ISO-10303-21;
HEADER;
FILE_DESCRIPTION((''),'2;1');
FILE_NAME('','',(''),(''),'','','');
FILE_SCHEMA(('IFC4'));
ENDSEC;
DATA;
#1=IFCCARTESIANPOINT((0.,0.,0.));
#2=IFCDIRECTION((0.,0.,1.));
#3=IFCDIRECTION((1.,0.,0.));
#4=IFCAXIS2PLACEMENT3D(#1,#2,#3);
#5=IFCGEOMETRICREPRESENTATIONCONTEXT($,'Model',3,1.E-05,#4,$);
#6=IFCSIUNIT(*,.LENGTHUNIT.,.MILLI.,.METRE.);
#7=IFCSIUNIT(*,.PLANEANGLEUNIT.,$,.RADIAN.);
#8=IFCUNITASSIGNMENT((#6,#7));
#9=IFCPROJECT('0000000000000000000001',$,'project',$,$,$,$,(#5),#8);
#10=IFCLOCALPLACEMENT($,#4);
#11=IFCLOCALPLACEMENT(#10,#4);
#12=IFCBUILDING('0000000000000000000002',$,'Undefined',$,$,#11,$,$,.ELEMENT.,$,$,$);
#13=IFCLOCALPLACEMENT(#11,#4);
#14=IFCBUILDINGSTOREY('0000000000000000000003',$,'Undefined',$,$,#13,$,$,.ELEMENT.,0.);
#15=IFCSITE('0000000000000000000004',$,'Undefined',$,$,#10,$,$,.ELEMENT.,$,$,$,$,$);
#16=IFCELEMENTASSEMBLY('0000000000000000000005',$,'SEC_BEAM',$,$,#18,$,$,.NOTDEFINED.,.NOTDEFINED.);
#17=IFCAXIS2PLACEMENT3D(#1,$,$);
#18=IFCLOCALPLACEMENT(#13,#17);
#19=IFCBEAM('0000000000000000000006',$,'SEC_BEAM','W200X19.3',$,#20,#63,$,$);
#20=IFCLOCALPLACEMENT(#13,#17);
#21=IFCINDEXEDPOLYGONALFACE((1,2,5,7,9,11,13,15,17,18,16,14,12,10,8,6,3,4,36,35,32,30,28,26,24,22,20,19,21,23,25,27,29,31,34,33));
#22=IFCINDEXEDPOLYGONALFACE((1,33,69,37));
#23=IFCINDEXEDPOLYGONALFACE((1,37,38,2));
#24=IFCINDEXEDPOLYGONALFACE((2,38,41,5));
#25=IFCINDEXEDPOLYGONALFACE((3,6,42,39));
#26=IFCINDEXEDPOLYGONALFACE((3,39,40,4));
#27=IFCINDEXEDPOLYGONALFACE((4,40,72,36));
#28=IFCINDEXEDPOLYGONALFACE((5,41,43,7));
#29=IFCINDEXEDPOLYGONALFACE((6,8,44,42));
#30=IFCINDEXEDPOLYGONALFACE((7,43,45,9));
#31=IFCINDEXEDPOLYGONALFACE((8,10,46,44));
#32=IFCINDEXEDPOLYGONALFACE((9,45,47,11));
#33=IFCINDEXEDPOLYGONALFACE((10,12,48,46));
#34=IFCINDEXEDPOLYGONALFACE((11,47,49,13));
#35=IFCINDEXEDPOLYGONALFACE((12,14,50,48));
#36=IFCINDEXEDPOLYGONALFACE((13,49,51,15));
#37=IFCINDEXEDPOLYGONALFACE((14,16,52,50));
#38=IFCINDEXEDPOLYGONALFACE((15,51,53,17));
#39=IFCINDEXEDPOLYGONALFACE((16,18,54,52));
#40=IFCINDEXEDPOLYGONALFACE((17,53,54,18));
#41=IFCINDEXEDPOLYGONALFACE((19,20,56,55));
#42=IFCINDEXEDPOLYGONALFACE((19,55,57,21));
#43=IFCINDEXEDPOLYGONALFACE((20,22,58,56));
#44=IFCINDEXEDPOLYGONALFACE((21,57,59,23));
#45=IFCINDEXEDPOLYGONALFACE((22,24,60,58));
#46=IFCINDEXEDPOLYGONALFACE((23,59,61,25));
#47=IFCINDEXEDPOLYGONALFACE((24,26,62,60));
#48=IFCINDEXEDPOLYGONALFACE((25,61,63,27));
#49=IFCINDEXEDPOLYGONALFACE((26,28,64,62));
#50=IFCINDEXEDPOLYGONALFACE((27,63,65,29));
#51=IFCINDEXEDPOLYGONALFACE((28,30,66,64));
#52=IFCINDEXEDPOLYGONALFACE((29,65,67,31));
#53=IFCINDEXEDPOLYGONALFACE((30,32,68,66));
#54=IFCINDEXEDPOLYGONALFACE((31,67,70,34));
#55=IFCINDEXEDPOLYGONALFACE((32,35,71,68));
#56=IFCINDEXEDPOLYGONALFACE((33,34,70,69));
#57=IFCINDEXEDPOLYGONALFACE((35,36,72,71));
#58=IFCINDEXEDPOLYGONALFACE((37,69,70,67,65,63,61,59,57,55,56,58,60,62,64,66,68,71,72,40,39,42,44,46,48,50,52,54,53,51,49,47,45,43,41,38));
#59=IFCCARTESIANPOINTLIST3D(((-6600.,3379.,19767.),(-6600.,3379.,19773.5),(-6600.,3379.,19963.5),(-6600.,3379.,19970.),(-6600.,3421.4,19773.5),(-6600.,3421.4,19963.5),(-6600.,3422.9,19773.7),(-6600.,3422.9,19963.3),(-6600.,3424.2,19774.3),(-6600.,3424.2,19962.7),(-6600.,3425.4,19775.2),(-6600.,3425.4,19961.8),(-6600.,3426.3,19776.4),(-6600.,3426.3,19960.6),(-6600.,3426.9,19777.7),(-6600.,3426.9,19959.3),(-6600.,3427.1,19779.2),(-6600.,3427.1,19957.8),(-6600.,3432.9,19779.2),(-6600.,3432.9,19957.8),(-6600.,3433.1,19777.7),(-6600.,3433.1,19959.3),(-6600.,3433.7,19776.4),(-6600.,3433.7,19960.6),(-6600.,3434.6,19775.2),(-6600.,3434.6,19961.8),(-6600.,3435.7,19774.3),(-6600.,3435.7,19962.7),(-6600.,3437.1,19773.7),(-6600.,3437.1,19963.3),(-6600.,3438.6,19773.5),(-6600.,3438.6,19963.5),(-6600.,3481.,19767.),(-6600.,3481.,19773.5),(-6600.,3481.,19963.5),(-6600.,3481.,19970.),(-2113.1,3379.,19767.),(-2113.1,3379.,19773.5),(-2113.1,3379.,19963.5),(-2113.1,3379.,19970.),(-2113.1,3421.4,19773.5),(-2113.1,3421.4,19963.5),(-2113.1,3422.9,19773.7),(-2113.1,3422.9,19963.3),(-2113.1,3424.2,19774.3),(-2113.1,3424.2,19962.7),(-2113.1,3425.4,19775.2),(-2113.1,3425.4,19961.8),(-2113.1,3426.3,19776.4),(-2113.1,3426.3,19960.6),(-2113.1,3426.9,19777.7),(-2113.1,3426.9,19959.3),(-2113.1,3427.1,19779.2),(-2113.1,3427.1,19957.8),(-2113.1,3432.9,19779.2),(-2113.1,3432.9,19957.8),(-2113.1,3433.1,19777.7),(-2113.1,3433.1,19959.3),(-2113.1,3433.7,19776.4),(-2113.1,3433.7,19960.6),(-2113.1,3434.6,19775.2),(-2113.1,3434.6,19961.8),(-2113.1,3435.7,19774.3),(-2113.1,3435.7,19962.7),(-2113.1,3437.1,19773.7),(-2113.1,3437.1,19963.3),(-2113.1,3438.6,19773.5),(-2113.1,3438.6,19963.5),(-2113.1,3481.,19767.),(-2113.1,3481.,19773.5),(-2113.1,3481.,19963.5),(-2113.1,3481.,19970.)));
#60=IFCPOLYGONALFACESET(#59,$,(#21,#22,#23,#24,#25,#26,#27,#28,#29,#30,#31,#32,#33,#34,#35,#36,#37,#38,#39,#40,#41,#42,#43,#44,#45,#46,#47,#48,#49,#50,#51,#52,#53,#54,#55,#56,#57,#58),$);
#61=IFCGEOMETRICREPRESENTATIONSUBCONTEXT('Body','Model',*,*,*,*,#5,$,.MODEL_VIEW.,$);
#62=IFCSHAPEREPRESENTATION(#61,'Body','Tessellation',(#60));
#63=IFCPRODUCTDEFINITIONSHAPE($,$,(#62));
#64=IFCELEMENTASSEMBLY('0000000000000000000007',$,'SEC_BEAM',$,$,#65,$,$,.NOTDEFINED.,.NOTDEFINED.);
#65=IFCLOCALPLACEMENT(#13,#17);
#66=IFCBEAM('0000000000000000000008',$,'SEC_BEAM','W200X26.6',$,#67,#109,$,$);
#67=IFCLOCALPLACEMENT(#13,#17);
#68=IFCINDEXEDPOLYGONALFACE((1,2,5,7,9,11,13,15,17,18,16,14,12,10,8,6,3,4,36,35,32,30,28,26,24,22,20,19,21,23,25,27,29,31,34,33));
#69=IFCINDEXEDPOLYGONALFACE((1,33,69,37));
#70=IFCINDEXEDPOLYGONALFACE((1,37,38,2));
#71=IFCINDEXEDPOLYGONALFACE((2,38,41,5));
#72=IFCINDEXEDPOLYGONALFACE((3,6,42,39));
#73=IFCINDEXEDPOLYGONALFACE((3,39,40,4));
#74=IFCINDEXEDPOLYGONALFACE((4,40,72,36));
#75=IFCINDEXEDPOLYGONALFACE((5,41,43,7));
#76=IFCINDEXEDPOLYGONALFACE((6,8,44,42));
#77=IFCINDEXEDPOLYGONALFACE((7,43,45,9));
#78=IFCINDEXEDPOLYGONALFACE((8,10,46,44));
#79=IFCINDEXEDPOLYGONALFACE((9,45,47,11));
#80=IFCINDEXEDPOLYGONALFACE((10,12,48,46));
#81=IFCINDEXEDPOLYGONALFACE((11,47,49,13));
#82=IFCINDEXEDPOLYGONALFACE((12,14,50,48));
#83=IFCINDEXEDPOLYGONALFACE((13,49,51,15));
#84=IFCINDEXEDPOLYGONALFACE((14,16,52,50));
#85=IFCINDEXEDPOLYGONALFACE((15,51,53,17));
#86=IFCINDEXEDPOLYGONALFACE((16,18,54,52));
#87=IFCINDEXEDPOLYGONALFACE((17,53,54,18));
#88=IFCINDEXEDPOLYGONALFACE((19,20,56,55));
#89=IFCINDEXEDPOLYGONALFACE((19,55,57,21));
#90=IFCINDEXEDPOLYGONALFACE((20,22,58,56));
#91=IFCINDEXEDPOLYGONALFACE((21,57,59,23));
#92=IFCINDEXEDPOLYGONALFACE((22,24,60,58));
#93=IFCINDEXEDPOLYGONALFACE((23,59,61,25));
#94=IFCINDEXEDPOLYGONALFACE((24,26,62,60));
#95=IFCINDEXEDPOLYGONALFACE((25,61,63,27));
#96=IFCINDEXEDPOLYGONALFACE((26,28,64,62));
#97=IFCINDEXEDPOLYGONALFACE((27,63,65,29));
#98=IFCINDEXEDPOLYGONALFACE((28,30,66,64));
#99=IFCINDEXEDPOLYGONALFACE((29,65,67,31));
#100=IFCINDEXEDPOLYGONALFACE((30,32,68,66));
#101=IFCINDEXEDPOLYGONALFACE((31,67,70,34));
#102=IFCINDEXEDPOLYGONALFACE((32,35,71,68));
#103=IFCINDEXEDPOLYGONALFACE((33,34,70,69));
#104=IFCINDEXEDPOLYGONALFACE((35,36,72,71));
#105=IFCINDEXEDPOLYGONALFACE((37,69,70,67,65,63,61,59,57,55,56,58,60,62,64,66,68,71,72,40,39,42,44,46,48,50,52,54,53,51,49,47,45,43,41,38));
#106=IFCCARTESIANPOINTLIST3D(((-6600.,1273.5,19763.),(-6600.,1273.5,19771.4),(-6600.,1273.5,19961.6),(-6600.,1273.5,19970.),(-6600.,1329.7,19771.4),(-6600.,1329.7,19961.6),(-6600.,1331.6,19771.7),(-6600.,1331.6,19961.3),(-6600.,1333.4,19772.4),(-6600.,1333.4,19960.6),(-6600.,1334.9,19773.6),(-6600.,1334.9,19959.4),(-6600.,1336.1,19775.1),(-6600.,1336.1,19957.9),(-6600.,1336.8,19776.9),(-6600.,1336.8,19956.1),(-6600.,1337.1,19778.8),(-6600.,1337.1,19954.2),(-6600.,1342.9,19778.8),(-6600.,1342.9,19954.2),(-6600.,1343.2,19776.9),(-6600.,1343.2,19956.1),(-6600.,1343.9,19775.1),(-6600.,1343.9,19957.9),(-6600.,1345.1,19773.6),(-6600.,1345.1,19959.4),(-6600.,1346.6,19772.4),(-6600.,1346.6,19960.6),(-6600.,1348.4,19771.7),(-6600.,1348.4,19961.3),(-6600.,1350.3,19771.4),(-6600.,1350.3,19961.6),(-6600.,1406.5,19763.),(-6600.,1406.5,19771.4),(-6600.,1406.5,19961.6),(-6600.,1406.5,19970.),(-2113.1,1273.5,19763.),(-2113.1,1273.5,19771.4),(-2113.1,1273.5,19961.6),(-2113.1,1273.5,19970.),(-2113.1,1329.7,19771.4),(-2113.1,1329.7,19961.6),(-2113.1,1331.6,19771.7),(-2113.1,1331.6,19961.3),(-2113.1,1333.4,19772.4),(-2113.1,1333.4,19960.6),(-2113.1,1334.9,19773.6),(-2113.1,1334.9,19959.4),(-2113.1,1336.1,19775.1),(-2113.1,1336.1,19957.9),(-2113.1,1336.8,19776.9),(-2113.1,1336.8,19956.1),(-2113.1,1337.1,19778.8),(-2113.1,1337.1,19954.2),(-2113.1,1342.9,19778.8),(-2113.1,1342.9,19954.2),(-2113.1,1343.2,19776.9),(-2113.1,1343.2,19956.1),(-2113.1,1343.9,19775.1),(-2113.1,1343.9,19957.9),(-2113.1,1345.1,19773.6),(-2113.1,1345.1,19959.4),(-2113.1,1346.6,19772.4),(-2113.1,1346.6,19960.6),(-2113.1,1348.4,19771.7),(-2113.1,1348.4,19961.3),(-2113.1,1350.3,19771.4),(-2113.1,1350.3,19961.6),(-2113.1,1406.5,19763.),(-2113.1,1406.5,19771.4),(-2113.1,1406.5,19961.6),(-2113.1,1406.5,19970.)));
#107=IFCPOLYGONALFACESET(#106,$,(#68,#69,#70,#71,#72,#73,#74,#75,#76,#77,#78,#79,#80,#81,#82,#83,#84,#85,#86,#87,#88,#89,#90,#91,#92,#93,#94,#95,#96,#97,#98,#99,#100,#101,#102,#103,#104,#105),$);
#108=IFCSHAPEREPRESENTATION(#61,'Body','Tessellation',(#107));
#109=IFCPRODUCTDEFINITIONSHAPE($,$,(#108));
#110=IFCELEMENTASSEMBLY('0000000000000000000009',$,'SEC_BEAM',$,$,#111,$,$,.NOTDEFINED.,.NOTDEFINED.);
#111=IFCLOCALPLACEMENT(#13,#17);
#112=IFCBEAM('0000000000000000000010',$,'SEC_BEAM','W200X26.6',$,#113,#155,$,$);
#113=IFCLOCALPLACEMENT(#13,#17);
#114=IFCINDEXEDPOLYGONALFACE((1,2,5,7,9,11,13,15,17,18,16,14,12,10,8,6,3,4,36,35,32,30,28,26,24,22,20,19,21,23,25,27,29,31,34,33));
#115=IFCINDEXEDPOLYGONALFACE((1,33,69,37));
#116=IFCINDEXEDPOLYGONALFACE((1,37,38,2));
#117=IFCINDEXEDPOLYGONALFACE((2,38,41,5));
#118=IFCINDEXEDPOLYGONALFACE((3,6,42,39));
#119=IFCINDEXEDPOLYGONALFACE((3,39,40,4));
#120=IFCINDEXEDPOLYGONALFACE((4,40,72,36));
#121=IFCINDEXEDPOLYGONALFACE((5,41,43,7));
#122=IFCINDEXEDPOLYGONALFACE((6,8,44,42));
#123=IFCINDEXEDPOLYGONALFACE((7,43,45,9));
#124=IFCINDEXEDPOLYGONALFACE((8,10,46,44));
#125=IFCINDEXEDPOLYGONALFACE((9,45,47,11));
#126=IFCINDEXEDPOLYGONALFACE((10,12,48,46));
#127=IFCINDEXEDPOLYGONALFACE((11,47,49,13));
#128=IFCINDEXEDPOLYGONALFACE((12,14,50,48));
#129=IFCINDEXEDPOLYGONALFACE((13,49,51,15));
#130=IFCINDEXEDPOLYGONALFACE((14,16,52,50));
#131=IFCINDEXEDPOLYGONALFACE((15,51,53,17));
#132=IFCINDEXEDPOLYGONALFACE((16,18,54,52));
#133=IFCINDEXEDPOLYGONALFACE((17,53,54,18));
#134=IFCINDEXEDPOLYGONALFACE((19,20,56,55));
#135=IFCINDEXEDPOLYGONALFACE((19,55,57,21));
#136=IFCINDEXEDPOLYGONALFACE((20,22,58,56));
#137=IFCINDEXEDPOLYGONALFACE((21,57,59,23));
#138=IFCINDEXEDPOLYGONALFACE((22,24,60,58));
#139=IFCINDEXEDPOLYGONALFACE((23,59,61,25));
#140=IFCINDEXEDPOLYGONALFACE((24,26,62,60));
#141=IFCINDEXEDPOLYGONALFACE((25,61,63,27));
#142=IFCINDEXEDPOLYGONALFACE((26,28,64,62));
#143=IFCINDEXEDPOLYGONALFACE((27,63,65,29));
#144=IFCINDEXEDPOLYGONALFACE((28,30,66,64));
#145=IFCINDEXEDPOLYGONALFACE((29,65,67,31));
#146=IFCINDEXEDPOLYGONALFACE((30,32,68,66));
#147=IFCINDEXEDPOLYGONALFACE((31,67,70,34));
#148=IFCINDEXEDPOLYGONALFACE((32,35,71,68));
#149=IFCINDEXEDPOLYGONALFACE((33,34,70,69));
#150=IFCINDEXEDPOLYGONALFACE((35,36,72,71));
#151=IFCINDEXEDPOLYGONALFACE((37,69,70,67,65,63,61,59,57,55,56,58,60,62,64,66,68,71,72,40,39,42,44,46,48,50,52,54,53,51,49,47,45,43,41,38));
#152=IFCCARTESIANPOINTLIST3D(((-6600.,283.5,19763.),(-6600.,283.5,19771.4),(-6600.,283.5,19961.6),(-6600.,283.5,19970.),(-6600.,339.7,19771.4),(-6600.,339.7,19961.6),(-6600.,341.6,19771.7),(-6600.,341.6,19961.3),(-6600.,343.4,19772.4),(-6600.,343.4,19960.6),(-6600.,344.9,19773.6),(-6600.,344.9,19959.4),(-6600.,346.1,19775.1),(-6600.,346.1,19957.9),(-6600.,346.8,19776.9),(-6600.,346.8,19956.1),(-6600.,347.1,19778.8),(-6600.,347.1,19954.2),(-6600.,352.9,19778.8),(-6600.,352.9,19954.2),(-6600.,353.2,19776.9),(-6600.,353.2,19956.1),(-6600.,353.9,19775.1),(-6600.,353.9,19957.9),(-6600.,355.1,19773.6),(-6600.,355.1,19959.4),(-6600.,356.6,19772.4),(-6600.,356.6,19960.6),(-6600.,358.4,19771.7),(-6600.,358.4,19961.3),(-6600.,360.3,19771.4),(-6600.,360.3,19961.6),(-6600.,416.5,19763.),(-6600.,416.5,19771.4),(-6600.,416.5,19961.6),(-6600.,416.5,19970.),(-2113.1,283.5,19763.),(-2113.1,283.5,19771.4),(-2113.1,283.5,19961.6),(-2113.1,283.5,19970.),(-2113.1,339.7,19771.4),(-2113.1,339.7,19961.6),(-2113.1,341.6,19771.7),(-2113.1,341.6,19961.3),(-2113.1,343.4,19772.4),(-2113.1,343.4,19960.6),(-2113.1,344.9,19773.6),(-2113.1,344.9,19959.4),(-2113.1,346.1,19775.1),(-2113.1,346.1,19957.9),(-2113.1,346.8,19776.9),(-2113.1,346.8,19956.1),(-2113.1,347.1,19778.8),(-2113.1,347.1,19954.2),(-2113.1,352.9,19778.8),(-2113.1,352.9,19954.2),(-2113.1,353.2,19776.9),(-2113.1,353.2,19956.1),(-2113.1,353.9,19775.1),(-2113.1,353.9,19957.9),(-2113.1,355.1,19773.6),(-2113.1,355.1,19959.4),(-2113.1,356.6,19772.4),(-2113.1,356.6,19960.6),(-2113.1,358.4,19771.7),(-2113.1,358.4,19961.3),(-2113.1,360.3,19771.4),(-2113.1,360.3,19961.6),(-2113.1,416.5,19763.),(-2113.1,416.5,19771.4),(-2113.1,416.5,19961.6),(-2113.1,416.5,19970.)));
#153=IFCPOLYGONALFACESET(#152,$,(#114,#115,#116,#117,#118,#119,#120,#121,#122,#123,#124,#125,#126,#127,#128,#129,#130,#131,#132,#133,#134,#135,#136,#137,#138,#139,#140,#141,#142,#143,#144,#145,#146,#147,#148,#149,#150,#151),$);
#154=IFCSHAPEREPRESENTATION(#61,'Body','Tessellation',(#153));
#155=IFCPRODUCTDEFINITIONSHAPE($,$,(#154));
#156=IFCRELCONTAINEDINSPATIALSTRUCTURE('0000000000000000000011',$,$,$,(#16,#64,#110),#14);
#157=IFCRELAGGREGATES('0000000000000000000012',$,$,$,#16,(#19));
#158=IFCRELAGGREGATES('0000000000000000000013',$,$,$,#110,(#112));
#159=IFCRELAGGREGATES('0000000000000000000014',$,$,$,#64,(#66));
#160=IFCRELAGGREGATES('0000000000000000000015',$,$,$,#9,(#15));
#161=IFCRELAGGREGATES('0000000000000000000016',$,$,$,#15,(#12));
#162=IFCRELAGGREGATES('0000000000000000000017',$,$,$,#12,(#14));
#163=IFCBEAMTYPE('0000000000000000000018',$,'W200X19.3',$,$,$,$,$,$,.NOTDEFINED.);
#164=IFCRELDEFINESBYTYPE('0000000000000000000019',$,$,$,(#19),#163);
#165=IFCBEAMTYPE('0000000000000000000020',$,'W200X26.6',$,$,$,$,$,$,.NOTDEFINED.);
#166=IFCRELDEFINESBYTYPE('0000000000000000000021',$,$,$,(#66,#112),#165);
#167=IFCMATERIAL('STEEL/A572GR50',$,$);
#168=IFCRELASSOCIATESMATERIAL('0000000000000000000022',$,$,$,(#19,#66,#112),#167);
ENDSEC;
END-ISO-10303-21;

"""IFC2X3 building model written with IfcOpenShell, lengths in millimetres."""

from ifc_helpers import new_model, si_unit, frame, origin_with_axes, origin_2d_with_axis, place, context, subcontext, project, spatial, i_section, extrude, clip, halfspace, material, type_object, element, aggregate, save


model = new_model("IFC2X3")

# Units and contexts
model_context = context("Model", 3, precision=1e-05, world=origin_with_axes())
body_context = subcontext(model_context, "Body", "Model", "MODEL_VIEW")
ifc_project = project(units=[si_unit("LENGTHUNIT", "METRE", prefix="MILLI"), si_unit("PLANEANGLEUNIT", "RADIAN")], contexts=[model_context])

# Site, building, storey
site_placement = place(None, origin_with_axes())
site = spatial("IfcSite", under=ifc_project, at=site_placement, Name="Undefined", CompositionType="ELEMENT")
building_placement = place(site_placement, origin_with_axes())
building = spatial("IfcBuilding", under=site, at=building_placement, Name="Undefined", CompositionType="ELEMENT")
storey_placement = place(building_placement, origin_with_axes())
storey = spatial("IfcBuildingStorey", under=building, at=storey_placement, Name="Undefined", CompositionType="ELEMENT", Elevation=0.0)

# Shared definitions
ifc_material_1 = material(Name="STEEL/A572GR50")

# Element assemblies, beams
beam_type_1 = type_object("IfcBeamType", Name="W200X19.3", PredefinedType="NOTDEFINED")
assembly_1_placement = place(storey_placement, origin_with_axes())
assembly_1 = element("IfcElementAssembly", 1, at=assembly_1_placement, inside=storey, Name="SEC_BEAM", AssemblyPlace="NOTDEFINED", PredefinedType="NOTDEFINED")
beam_1_placement = place(assembly_1_placement, frame((-2113.1, 3430.0, 19868.5), z_axis=(0.0, 0.0, 1.0), x_axis=(-1.0, 0.0, 0.0)))
beam_1 = element("IfcBeam", 2, at=beam_1_placement, type_object=beam_type_1, material=ifc_material_1, Name="SEC_BEAM", Description="W200X19.3", context=body_context, shape_type="Clipping", body=[
    clip(extrude(i_section(OverallWidth=102.0, OverallDepth=203.0, WebThickness=5.8, FlangeThickness=6.5, FilletRadius=5.7, at=origin_2d_with_axis()), frame((4486.9, 0.0, 0.0), z_axis=(-1.0, 0.0, 0.0), x_axis=(0.0, -1.0, 0.0)), (0.0, 0.0, 1.0), 4486.9), halfspace(frame((4486.9, 0.0, 0.0), z_axis=(-1.0, 0.0, 0.0), x_axis=(0.0, 1.0, 0.0)), True)),
])
assembly_2_placement = place(storey_placement, origin_with_axes())
assembly_2 = element("IfcElementAssembly", 3, at=assembly_2_placement, inside=storey, Name="SEC_BEAM", AssemblyPlace="NOTDEFINED", PredefinedType="NOTDEFINED")
beam_type_2 = type_object("IfcBeamType", Name="W200X26.6", PredefinedType="NOTDEFINED")
beam_2_placement = place(assembly_2_placement, frame((-2113.1, 1340.0, 19866.5), z_axis=(0.0, 0.0, 1.0), x_axis=(-1.0, 0.0, 0.0)))
beam_2 = element("IfcBeam", 4, at=beam_2_placement, type_object=beam_type_2, material=ifc_material_1, Name="SEC_BEAM", Description="W200X26.6", context=body_context, shape_type="Clipping", body=[
    clip(extrude(i_section(OverallWidth=133.0, OverallDepth=207.0, WebThickness=5.8, FlangeThickness=8.4, FilletRadius=7.4, at=origin_2d_with_axis()), frame((4486.9, 0.0, 0.0), z_axis=(-1.0, 0.0, 0.0), x_axis=(0.0, -1.0, 0.0)), (0.0, 0.0, 1.0), 4486.9), halfspace(frame((4486.9, 0.0, 0.0), z_axis=(-1.0, 0.0, 0.0), x_axis=(0.0, 1.0, 0.0)), True)),
])
assembly_3_placement = place(storey_placement, origin_with_axes())
assembly_3 = element("IfcElementAssembly", 5, at=assembly_3_placement, inside=storey, Name="SEC_BEAM", AssemblyPlace="NOTDEFINED", PredefinedType="NOTDEFINED")
beam_3_placement = place(assembly_3_placement, frame((-2113.1, 350.0, 19866.5), z_axis=(0.0, 0.0, 1.0), x_axis=(-1.0, 0.0, 0.0)))
beam_3 = element("IfcBeam", 6, at=beam_3_placement, type_object=beam_type_2, material=ifc_material_1, Name="SEC_BEAM", Description="W200X26.6", context=body_context, shape_type="Clipping", body=[
    clip(extrude(i_section(OverallWidth=133.0, OverallDepth=207.0, WebThickness=5.8, FlangeThickness=8.4, FilletRadius=7.4, at=origin_2d_with_axis()), frame((4486.9, 0.0, 0.0), z_axis=(-1.0, 0.0, 0.0), x_axis=(0.0, -1.0, 0.0)), (0.0, 0.0, 1.0), 4486.9), halfspace(frame((4486.9, 0.0, 0.0), z_axis=(-1.0, 0.0, 0.0), x_axis=(0.0, 1.0, 0.0)), True)),
])

aggregate(assembly_1, [beam_1])
aggregate(assembly_3, [beam_3])
aggregate(assembly_2, [beam_2])

save(model, "model.ifc")
